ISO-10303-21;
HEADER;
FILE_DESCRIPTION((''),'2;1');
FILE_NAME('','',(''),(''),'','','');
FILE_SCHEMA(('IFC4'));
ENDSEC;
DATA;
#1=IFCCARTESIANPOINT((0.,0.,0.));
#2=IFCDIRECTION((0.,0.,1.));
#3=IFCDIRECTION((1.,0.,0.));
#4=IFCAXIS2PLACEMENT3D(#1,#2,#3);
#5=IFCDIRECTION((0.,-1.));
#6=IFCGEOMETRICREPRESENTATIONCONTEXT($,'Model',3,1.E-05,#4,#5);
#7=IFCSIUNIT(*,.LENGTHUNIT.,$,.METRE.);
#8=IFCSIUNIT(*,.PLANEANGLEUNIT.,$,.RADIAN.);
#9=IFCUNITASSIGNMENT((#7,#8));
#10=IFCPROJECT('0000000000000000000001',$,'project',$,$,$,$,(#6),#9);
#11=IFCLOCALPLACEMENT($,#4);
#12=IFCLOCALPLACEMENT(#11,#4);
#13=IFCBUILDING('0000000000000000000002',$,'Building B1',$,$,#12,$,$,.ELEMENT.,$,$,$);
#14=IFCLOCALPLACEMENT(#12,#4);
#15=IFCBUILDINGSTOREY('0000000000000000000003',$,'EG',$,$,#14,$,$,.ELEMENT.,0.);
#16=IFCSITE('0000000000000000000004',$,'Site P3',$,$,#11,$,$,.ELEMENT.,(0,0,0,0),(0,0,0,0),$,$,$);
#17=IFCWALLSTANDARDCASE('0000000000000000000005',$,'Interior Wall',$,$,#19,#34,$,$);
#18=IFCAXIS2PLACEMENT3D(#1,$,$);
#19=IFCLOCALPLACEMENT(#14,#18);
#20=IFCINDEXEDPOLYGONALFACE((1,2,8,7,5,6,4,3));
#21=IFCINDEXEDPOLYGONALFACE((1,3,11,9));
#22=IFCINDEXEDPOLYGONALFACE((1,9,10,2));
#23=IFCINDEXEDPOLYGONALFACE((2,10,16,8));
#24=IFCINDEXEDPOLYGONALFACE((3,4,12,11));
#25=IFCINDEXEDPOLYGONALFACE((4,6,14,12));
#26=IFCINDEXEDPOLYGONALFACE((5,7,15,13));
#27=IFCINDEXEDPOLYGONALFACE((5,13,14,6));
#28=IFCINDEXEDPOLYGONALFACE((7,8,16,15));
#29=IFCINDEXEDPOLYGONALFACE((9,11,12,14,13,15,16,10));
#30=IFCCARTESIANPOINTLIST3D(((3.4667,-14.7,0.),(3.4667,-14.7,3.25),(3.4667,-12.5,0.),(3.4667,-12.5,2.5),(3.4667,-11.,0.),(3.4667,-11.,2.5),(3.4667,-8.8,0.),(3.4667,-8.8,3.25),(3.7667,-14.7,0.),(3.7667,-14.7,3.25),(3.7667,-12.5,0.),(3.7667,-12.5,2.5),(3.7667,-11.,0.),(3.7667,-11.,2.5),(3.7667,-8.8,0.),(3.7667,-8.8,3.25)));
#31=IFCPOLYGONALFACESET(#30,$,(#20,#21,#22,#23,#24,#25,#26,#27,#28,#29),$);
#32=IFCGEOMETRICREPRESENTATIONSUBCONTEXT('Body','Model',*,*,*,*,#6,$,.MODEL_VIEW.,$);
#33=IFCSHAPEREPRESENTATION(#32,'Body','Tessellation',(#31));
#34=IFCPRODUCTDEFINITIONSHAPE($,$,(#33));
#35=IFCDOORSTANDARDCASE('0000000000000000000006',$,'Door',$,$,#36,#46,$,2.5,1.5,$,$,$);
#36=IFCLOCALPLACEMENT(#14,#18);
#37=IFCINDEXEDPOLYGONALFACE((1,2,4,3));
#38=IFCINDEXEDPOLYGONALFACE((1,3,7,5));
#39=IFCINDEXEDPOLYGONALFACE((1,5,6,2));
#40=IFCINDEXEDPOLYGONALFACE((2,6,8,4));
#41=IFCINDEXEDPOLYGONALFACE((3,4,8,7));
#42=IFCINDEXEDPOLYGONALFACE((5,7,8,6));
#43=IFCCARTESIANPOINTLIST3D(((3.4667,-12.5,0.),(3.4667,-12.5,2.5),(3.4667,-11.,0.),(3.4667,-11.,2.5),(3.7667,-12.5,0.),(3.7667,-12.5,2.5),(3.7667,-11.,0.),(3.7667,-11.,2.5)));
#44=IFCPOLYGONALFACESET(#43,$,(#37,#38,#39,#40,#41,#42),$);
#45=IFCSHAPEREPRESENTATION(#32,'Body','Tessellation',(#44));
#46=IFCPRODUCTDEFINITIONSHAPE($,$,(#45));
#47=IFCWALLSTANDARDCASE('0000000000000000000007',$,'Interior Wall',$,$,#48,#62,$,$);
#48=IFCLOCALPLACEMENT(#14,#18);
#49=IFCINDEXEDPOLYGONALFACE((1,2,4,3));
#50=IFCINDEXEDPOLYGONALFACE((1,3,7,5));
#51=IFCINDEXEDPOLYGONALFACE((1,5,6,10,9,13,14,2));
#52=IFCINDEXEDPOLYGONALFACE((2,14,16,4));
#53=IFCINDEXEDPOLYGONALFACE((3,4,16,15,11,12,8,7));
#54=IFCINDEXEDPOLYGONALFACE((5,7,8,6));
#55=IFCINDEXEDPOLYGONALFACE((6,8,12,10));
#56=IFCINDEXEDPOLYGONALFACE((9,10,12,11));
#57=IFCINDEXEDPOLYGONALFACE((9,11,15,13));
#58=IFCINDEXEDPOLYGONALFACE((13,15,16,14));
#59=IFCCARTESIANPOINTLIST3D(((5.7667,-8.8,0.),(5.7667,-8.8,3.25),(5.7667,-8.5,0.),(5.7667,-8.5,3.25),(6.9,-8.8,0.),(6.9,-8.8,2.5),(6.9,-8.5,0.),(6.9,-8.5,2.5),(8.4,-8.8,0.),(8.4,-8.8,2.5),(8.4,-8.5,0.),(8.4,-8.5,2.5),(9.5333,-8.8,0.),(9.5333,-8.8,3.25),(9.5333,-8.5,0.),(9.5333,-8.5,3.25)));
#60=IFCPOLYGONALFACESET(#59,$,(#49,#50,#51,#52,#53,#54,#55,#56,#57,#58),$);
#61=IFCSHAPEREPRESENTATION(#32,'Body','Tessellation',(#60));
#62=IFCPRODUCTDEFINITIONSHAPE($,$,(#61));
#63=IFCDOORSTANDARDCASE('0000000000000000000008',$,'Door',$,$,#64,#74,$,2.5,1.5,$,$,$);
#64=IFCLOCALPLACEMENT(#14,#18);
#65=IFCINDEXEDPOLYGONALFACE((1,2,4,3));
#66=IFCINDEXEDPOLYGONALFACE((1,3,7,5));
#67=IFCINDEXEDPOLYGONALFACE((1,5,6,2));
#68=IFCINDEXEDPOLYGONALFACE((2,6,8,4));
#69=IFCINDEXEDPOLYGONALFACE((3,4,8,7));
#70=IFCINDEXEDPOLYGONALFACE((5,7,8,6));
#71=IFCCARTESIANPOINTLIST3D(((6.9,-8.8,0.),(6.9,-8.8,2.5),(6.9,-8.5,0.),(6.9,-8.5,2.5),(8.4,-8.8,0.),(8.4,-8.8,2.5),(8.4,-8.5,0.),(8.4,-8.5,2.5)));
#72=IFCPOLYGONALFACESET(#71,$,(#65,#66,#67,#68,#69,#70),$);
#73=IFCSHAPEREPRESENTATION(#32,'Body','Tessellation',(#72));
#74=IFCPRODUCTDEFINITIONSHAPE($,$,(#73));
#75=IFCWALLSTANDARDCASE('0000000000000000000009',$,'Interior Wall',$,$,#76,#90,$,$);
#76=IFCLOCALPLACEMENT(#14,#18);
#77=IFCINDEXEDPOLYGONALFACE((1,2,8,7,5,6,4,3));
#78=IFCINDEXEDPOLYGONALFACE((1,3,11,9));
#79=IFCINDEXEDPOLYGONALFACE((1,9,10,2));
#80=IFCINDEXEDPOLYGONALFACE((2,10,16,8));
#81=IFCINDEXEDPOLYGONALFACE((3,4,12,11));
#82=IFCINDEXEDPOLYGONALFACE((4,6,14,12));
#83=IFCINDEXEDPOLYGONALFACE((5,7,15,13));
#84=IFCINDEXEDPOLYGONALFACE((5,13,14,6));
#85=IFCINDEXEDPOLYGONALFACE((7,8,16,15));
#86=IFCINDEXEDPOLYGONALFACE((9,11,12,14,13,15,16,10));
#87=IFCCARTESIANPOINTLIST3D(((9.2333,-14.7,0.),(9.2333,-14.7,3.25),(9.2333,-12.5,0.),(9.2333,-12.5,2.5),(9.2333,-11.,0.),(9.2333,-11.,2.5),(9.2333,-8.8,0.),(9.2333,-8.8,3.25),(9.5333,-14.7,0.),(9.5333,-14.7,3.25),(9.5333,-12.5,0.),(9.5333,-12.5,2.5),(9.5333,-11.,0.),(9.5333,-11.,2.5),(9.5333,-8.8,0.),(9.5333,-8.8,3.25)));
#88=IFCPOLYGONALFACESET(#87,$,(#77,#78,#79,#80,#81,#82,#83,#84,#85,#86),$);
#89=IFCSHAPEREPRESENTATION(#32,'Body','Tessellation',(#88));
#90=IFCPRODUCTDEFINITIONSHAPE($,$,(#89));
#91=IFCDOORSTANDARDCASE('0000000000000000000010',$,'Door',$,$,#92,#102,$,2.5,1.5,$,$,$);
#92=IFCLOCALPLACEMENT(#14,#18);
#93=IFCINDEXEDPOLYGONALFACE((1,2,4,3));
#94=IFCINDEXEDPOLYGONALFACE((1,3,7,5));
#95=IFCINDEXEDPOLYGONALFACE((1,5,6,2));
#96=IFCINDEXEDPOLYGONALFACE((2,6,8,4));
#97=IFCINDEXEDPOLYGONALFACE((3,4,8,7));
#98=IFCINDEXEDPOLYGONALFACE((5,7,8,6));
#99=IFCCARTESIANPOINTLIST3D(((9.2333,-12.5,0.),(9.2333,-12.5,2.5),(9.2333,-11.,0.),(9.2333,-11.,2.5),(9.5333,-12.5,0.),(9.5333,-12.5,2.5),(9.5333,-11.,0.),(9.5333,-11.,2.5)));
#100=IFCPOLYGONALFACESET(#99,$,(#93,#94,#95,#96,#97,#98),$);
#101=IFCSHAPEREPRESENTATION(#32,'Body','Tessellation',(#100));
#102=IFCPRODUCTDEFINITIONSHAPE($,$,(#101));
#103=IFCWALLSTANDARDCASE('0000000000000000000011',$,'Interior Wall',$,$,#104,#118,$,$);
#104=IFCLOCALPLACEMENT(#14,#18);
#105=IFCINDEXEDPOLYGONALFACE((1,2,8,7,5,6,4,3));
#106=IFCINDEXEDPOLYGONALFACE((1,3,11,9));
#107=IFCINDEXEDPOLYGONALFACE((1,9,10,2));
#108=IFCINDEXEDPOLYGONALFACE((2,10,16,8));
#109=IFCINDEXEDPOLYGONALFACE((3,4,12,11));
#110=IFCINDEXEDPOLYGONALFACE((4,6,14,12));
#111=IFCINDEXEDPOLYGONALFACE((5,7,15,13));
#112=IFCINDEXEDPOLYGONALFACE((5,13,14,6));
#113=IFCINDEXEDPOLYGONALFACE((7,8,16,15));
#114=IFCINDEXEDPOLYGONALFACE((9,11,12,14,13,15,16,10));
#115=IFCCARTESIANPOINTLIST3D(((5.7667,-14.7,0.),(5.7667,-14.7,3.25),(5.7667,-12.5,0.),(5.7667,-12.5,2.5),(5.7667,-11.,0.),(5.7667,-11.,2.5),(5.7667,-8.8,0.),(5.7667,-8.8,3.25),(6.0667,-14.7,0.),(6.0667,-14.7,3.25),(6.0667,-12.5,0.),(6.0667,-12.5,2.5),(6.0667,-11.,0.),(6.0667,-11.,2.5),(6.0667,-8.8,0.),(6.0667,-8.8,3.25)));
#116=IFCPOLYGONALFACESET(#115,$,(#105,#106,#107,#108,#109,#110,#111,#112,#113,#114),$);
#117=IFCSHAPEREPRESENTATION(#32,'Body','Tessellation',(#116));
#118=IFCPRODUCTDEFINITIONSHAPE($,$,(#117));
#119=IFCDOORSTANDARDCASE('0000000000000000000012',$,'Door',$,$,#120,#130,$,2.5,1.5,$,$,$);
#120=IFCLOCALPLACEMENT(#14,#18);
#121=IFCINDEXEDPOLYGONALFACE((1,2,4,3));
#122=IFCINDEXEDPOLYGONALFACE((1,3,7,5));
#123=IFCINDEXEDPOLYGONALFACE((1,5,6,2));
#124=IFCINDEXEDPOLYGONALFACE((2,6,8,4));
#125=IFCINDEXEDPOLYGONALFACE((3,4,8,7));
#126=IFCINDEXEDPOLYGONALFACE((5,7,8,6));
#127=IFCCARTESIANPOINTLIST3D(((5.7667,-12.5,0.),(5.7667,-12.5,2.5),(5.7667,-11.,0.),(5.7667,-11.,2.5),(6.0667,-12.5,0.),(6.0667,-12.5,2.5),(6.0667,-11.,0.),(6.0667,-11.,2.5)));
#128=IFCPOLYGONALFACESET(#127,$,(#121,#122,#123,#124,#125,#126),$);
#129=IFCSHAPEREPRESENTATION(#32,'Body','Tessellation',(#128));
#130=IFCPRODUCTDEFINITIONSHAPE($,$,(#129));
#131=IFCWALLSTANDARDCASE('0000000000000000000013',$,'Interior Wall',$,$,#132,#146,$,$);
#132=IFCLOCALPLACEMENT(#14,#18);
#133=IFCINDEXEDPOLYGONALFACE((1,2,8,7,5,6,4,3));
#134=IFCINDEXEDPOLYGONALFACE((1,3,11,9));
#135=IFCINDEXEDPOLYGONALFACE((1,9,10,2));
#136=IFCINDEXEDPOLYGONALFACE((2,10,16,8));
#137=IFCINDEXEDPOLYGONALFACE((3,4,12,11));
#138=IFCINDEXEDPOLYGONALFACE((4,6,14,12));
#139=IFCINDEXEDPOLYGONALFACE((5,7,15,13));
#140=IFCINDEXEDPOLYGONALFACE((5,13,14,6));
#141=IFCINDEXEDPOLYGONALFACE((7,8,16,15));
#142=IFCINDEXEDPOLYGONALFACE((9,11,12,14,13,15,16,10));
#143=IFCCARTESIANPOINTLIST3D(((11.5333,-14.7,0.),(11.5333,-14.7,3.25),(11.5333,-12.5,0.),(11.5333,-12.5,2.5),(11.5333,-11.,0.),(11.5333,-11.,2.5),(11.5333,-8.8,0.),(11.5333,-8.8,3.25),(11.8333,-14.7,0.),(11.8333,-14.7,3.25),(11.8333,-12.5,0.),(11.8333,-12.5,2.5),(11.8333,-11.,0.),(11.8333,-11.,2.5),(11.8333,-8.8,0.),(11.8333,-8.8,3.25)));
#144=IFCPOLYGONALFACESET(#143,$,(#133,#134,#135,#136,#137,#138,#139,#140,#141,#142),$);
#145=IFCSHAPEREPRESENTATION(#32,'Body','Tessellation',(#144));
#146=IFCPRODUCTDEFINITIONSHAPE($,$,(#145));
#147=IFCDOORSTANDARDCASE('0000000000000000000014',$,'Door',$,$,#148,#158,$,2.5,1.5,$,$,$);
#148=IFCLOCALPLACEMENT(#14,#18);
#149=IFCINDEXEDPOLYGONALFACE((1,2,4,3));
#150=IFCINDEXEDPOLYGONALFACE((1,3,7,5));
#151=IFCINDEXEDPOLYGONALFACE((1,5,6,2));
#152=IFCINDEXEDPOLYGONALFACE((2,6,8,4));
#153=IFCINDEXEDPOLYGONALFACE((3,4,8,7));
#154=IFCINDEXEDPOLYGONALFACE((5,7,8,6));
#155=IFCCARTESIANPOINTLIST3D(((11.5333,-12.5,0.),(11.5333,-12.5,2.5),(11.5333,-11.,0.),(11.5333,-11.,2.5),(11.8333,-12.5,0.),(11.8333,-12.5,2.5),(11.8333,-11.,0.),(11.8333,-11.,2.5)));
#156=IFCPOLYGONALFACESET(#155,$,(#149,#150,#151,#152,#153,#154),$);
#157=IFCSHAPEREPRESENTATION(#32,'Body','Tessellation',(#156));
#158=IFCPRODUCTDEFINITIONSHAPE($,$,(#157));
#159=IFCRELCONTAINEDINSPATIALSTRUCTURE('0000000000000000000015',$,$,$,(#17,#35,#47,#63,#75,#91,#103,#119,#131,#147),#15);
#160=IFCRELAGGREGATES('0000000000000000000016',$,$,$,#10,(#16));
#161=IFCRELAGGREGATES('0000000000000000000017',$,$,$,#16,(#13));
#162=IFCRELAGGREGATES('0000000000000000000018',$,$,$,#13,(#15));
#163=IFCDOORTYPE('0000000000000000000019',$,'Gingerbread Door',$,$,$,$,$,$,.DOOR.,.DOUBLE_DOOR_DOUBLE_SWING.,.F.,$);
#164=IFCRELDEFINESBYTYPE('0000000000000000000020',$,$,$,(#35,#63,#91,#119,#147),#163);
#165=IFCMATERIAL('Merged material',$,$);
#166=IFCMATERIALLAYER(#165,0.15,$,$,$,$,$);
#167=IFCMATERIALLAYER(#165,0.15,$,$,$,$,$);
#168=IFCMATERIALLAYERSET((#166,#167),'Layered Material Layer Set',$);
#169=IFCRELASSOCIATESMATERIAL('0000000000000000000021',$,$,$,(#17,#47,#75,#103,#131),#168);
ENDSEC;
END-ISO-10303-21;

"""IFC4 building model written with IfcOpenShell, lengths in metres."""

from ifc_helpers import new_model, si_unit, direction, frame, origin_with_axes, place, context, subcontext, project, spatial, polyline, outline, extrude, source, transform, mapped, material, layer, layer_set, layer_usage, type_object, element, fill, save


model = new_model("IFC4")

# Units and contexts
model_context = context("Model", 3, precision=1e-05, world=origin_with_axes(), true_north=direction((0.0, -1.0)))
body_context = subcontext(model_context, "Body", "Model", "MODEL_VIEW")
ifc_project = project(units=[si_unit("LENGTHUNIT", "METRE"), si_unit("PLANEANGLEUNIT", "RADIAN")], contexts=[model_context])

# Site, building, storey
site_placement = place(None, origin_with_axes())
site = spatial("IfcSite", under=ifc_project, at=site_placement, Name="Site P3", CompositionType="ELEMENT", RefLatitude=(0, 0, 0, 0), RefLongitude=(0, 0, 0, 0))
building_placement = place(site_placement, origin_with_axes())
building = spatial("IfcBuilding", under=site, at=building_placement, Name="Building B1", CompositionType="ELEMENT")
storey_placement = place(building_placement, origin_with_axes())
storey = spatial("IfcBuildingStorey", under=building, at=storey_placement, Name="EG", CompositionType="ELEMENT", Elevation=0.0)

# Shared definitions
ifc_material = material(Name="Merged material")

# Shared definitions
ifc_layer_1 = layer(ifc_material, 0.15)
ifc_layer_2 = layer(ifc_material, 0.15)
ifc_layer_set_1 = layer_set([ifc_layer_1, ifc_layer_2], Name="Layered Material Layer Set")
ifc_layer_usage_1 = layer_usage(ifc_layer_set_1, "AXIS2", "POSITIVE", -0.15)
door_type = type_object("IfcDoorType", Name="Gingerbread Door", OperationType="DOUBLE_DOOR_DOUBLE_SWING", ParameterTakesPrecedence=False, PredefinedType="DOOR")
shared_shape_1 = source(origin_with_axes(), body_context, "Body", "SweptSolid", [
    extrude(outline(polyline([(0.0, 0.0), (0.0, 1.5), (2.5, 1.5), (2.5, 0.0), (0.0, 0.0)])), frame((0.0, -0.15, 0.0), z_axis=(0.0, 1.0, 0.0), x_axis=(0.0, 0.0, 1.0)), (0.0, 0.0, 1.0), 0.3),
])

# Walls, openings, doors
wall_1_placement = place(storey_placement, frame((3.6167, -8.8, 0.0), z_axis=(0.0, 0.0, 1.0), x_axis=(0.0, -1.0, 0.0)))
wall_1 = element("IfcWallStandardCase", 1, at=wall_1_placement, inside=storey, material=ifc_layer_usage_1, Name="Interior Wall", context=body_context, shape_type="SweptSolid", body=[
    extrude(outline(polyline([(0.0, 0.15), (5.9, 0.15), (5.9, -0.15), (0.0, -0.15), (0.0, 0.15)])), origin_with_axes(), (0.0, 0.0, 1.0), 3.25),
])
opening_1_placement = place(wall_1_placement, frame((2.2, 0.0, 0.0), z_axis=(0.0, 0.0, 1.0), x_axis=(1.0, 0.0, 0.0)))
opening_1 = element("IfcOpeningStandardCase", 2, at=opening_1_placement, cuts=wall_1, context=body_context, shape_type="SweptSolid", body=[
    extrude(outline(polyline([(0.0, 0.0), (0.0, 1.5), (2.5, 1.5), (2.5, 0.0), (0.0, 0.0)])), frame((0.0, -0.15, 0.0), z_axis=(0.0, 1.0, 0.0), x_axis=(0.0, 0.0, 1.0)), (0.0, 0.0, 1.0), 0.3),
])
door_1_placement = place(opening_1_placement, origin_with_axes())
door_1 = element("IfcDoorStandardCase", 3, at=door_1_placement, inside=storey, type_object=door_type, Name="Door", OverallHeight=2.5, OverallWidth=1.5, context=body_context, shape_type="MappedRepresentation", body=[
    mapped(shared_shape_1, transform((0.0, 0.0, 0.0))),
])
fill(opening_1, door_1)
wall_2_placement = place(storey_placement, frame((5.7667, -8.65, 0.0), z_axis=(0.0, 0.0, 1.0), x_axis=(1.0, 0.0, 0.0)))
wall_2 = element("IfcWallStandardCase", 4, at=wall_2_placement, inside=storey, material=ifc_layer_usage_1, Name="Interior Wall", context=body_context, shape_type="SweptSolid", body=[
    extrude(outline(polyline([(0.0, 0.15), (3.7667, 0.15), (3.7667, -0.15), (0.0, -0.15), (0.0, 0.15)])), origin_with_axes(), (0.0, 0.0, 1.0), 3.25),
])
opening_2_placement = place(wall_2_placement, frame((1.1333, 0.0, 0.0), z_axis=(0.0, 0.0, 1.0), x_axis=(1.0, 0.0, 0.0)))
opening_2 = element("IfcOpeningStandardCase", 5, at=opening_2_placement, cuts=wall_2, context=body_context, shape_type="SweptSolid", body=[
    extrude(outline(polyline([(0.0, 0.0), (0.0, 1.5), (2.5, 1.5), (2.5, 0.0), (0.0, 0.0)])), frame((0.0, -0.15, 0.0), z_axis=(0.0, 1.0, 0.0), x_axis=(0.0, 0.0, 1.0)), (0.0, 0.0, 1.0), 0.3),
])
door_2_placement = place(opening_2_placement, origin_with_axes())
door_2 = element("IfcDoorStandardCase", 6, at=door_2_placement, inside=storey, type_object=door_type, Name="Door", OverallHeight=2.5, OverallWidth=1.5, context=body_context, shape_type="MappedRepresentation", body=[
    mapped(shared_shape_1, transform((0.0, 0.0, 0.0))),
])
fill(opening_2, door_2)
wall_3_placement = place(storey_placement, frame((9.3833, -8.8, 0.0), z_axis=(0.0, 0.0, 1.0), x_axis=(0.0, -1.0, 0.0)))
wall_3 = element("IfcWallStandardCase", 7, at=wall_3_placement, inside=storey, material=ifc_layer_usage_1, Name="Interior Wall", context=body_context, shape_type="SweptSolid", body=[
    extrude(outline(polyline([(0.0, 0.15), (5.9, 0.15), (5.9, -0.15), (0.0, -0.15), (0.0, 0.15)])), origin_with_axes(), (0.0, 0.0, 1.0), 3.25),
])
opening_3_placement = place(wall_3_placement, frame((2.2, 0.0, 0.0), z_axis=(0.0, 0.0, 1.0), x_axis=(1.0, 0.0, 0.0)))
opening_3 = element("IfcOpeningStandardCase", 8, at=opening_3_placement, cuts=wall_3, context=body_context, shape_type="SweptSolid", body=[
    extrude(outline(polyline([(0.0, 0.0), (0.0, 1.5), (2.5, 1.5), (2.5, 0.0), (0.0, 0.0)])), frame((0.0, -0.15, 0.0), z_axis=(0.0, 1.0, 0.0), x_axis=(0.0, 0.0, 1.0)), (0.0, 0.0, 1.0), 0.3),
])
door_3_placement = place(opening_3_placement, origin_with_axes())
door_3 = element("IfcDoorStandardCase", 9, at=door_3_placement, inside=storey, type_object=door_type, Name="Door", OverallHeight=2.5, OverallWidth=1.5, context=body_context, shape_type="MappedRepresentation", body=[
    mapped(shared_shape_1, transform((0.0, 0.0, 0.0))),
])
fill(opening_3, door_3)
wall_4_placement = place(storey_placement, frame((5.9167, -8.8, 0.0), z_axis=(0.0, 0.0, 1.0), x_axis=(0.0, -1.0, 0.0)))
wall_4 = element("IfcWallStandardCase", 10, at=wall_4_placement, inside=storey, material=ifc_layer_usage_1, Name="Interior Wall", context=body_context, shape_type="SweptSolid", body=[
    extrude(outline(polyline([(0.0, 0.15), (5.9, 0.15), (5.9, -0.15), (0.0, -0.15), (0.0, 0.15)])), origin_with_axes(), (0.0, 0.0, 1.0), 3.25),
])
opening_4_placement = place(wall_4_placement, frame((2.2, 0.0, 0.0), z_axis=(0.0, 0.0, 1.0), x_axis=(1.0, 0.0, 0.0)))
opening_4 = element("IfcOpeningStandardCase", 11, at=opening_4_placement, cuts=wall_4, context=body_context, shape_type="SweptSolid", body=[
    extrude(outline(polyline([(0.0, 0.0), (0.0, 1.5), (2.5, 1.5), (2.5, 0.0), (0.0, 0.0)])), frame((0.0, -0.15, 0.0), z_axis=(0.0, 1.0, 0.0), x_axis=(0.0, 0.0, 1.0)), (0.0, 0.0, 1.0), 0.3),
])
door_4_placement = place(opening_4_placement, origin_with_axes())
door_4 = element("IfcDoorStandardCase", 12, at=door_4_placement, inside=storey, type_object=door_type, Name="Door", OverallHeight=2.5, OverallWidth=1.5, context=body_context, shape_type="MappedRepresentation", body=[
    mapped(shared_shape_1, transform((0.0, 0.0, 0.0))),
])
fill(opening_4, door_4)
wall_5_placement = place(storey_placement, frame((11.6833, -8.8, 0.0), z_axis=(0.0, 0.0, 1.0), x_axis=(0.0, -1.0, 0.0)))
wall_5 = element("IfcWallStandardCase", 13, at=wall_5_placement, inside=storey, material=ifc_layer_usage_1, Name="Interior Wall", context=body_context, shape_type="SweptSolid", body=[
    extrude(outline(polyline([(0.0, 0.15), (5.9, 0.15), (5.9, -0.15), (0.0, -0.15), (0.0, 0.15)])), origin_with_axes(), (0.0, 0.0, 1.0), 3.25),
])
opening_5_placement = place(wall_5_placement, frame((2.2, 0.0, 0.0), z_axis=(0.0, 0.0, 1.0), x_axis=(1.0, 0.0, 0.0)))
opening_5 = element("IfcOpeningStandardCase", 14, at=opening_5_placement, cuts=wall_5, context=body_context, shape_type="SweptSolid", body=[
    extrude(outline(polyline([(0.0, 0.0), (0.0, 1.5), (2.5, 1.5), (2.5, 0.0), (0.0, 0.0)])), frame((0.0, -0.15, 0.0), z_axis=(0.0, 1.0, 0.0), x_axis=(0.0, 0.0, 1.0)), (0.0, 0.0, 1.0), 0.3),
])
door_5_placement = place(opening_5_placement, origin_with_axes())
door_5 = element("IfcDoorStandardCase", 15, at=door_5_placement, inside=storey, type_object=door_type, Name="Door", OverallHeight=2.5, OverallWidth=1.5, context=body_context, shape_type="MappedRepresentation", body=[
    mapped(shared_shape_1, transform((0.0, 0.0, 0.0))),
])
fill(opening_5, door_5)

save(model, "model.ifc")
